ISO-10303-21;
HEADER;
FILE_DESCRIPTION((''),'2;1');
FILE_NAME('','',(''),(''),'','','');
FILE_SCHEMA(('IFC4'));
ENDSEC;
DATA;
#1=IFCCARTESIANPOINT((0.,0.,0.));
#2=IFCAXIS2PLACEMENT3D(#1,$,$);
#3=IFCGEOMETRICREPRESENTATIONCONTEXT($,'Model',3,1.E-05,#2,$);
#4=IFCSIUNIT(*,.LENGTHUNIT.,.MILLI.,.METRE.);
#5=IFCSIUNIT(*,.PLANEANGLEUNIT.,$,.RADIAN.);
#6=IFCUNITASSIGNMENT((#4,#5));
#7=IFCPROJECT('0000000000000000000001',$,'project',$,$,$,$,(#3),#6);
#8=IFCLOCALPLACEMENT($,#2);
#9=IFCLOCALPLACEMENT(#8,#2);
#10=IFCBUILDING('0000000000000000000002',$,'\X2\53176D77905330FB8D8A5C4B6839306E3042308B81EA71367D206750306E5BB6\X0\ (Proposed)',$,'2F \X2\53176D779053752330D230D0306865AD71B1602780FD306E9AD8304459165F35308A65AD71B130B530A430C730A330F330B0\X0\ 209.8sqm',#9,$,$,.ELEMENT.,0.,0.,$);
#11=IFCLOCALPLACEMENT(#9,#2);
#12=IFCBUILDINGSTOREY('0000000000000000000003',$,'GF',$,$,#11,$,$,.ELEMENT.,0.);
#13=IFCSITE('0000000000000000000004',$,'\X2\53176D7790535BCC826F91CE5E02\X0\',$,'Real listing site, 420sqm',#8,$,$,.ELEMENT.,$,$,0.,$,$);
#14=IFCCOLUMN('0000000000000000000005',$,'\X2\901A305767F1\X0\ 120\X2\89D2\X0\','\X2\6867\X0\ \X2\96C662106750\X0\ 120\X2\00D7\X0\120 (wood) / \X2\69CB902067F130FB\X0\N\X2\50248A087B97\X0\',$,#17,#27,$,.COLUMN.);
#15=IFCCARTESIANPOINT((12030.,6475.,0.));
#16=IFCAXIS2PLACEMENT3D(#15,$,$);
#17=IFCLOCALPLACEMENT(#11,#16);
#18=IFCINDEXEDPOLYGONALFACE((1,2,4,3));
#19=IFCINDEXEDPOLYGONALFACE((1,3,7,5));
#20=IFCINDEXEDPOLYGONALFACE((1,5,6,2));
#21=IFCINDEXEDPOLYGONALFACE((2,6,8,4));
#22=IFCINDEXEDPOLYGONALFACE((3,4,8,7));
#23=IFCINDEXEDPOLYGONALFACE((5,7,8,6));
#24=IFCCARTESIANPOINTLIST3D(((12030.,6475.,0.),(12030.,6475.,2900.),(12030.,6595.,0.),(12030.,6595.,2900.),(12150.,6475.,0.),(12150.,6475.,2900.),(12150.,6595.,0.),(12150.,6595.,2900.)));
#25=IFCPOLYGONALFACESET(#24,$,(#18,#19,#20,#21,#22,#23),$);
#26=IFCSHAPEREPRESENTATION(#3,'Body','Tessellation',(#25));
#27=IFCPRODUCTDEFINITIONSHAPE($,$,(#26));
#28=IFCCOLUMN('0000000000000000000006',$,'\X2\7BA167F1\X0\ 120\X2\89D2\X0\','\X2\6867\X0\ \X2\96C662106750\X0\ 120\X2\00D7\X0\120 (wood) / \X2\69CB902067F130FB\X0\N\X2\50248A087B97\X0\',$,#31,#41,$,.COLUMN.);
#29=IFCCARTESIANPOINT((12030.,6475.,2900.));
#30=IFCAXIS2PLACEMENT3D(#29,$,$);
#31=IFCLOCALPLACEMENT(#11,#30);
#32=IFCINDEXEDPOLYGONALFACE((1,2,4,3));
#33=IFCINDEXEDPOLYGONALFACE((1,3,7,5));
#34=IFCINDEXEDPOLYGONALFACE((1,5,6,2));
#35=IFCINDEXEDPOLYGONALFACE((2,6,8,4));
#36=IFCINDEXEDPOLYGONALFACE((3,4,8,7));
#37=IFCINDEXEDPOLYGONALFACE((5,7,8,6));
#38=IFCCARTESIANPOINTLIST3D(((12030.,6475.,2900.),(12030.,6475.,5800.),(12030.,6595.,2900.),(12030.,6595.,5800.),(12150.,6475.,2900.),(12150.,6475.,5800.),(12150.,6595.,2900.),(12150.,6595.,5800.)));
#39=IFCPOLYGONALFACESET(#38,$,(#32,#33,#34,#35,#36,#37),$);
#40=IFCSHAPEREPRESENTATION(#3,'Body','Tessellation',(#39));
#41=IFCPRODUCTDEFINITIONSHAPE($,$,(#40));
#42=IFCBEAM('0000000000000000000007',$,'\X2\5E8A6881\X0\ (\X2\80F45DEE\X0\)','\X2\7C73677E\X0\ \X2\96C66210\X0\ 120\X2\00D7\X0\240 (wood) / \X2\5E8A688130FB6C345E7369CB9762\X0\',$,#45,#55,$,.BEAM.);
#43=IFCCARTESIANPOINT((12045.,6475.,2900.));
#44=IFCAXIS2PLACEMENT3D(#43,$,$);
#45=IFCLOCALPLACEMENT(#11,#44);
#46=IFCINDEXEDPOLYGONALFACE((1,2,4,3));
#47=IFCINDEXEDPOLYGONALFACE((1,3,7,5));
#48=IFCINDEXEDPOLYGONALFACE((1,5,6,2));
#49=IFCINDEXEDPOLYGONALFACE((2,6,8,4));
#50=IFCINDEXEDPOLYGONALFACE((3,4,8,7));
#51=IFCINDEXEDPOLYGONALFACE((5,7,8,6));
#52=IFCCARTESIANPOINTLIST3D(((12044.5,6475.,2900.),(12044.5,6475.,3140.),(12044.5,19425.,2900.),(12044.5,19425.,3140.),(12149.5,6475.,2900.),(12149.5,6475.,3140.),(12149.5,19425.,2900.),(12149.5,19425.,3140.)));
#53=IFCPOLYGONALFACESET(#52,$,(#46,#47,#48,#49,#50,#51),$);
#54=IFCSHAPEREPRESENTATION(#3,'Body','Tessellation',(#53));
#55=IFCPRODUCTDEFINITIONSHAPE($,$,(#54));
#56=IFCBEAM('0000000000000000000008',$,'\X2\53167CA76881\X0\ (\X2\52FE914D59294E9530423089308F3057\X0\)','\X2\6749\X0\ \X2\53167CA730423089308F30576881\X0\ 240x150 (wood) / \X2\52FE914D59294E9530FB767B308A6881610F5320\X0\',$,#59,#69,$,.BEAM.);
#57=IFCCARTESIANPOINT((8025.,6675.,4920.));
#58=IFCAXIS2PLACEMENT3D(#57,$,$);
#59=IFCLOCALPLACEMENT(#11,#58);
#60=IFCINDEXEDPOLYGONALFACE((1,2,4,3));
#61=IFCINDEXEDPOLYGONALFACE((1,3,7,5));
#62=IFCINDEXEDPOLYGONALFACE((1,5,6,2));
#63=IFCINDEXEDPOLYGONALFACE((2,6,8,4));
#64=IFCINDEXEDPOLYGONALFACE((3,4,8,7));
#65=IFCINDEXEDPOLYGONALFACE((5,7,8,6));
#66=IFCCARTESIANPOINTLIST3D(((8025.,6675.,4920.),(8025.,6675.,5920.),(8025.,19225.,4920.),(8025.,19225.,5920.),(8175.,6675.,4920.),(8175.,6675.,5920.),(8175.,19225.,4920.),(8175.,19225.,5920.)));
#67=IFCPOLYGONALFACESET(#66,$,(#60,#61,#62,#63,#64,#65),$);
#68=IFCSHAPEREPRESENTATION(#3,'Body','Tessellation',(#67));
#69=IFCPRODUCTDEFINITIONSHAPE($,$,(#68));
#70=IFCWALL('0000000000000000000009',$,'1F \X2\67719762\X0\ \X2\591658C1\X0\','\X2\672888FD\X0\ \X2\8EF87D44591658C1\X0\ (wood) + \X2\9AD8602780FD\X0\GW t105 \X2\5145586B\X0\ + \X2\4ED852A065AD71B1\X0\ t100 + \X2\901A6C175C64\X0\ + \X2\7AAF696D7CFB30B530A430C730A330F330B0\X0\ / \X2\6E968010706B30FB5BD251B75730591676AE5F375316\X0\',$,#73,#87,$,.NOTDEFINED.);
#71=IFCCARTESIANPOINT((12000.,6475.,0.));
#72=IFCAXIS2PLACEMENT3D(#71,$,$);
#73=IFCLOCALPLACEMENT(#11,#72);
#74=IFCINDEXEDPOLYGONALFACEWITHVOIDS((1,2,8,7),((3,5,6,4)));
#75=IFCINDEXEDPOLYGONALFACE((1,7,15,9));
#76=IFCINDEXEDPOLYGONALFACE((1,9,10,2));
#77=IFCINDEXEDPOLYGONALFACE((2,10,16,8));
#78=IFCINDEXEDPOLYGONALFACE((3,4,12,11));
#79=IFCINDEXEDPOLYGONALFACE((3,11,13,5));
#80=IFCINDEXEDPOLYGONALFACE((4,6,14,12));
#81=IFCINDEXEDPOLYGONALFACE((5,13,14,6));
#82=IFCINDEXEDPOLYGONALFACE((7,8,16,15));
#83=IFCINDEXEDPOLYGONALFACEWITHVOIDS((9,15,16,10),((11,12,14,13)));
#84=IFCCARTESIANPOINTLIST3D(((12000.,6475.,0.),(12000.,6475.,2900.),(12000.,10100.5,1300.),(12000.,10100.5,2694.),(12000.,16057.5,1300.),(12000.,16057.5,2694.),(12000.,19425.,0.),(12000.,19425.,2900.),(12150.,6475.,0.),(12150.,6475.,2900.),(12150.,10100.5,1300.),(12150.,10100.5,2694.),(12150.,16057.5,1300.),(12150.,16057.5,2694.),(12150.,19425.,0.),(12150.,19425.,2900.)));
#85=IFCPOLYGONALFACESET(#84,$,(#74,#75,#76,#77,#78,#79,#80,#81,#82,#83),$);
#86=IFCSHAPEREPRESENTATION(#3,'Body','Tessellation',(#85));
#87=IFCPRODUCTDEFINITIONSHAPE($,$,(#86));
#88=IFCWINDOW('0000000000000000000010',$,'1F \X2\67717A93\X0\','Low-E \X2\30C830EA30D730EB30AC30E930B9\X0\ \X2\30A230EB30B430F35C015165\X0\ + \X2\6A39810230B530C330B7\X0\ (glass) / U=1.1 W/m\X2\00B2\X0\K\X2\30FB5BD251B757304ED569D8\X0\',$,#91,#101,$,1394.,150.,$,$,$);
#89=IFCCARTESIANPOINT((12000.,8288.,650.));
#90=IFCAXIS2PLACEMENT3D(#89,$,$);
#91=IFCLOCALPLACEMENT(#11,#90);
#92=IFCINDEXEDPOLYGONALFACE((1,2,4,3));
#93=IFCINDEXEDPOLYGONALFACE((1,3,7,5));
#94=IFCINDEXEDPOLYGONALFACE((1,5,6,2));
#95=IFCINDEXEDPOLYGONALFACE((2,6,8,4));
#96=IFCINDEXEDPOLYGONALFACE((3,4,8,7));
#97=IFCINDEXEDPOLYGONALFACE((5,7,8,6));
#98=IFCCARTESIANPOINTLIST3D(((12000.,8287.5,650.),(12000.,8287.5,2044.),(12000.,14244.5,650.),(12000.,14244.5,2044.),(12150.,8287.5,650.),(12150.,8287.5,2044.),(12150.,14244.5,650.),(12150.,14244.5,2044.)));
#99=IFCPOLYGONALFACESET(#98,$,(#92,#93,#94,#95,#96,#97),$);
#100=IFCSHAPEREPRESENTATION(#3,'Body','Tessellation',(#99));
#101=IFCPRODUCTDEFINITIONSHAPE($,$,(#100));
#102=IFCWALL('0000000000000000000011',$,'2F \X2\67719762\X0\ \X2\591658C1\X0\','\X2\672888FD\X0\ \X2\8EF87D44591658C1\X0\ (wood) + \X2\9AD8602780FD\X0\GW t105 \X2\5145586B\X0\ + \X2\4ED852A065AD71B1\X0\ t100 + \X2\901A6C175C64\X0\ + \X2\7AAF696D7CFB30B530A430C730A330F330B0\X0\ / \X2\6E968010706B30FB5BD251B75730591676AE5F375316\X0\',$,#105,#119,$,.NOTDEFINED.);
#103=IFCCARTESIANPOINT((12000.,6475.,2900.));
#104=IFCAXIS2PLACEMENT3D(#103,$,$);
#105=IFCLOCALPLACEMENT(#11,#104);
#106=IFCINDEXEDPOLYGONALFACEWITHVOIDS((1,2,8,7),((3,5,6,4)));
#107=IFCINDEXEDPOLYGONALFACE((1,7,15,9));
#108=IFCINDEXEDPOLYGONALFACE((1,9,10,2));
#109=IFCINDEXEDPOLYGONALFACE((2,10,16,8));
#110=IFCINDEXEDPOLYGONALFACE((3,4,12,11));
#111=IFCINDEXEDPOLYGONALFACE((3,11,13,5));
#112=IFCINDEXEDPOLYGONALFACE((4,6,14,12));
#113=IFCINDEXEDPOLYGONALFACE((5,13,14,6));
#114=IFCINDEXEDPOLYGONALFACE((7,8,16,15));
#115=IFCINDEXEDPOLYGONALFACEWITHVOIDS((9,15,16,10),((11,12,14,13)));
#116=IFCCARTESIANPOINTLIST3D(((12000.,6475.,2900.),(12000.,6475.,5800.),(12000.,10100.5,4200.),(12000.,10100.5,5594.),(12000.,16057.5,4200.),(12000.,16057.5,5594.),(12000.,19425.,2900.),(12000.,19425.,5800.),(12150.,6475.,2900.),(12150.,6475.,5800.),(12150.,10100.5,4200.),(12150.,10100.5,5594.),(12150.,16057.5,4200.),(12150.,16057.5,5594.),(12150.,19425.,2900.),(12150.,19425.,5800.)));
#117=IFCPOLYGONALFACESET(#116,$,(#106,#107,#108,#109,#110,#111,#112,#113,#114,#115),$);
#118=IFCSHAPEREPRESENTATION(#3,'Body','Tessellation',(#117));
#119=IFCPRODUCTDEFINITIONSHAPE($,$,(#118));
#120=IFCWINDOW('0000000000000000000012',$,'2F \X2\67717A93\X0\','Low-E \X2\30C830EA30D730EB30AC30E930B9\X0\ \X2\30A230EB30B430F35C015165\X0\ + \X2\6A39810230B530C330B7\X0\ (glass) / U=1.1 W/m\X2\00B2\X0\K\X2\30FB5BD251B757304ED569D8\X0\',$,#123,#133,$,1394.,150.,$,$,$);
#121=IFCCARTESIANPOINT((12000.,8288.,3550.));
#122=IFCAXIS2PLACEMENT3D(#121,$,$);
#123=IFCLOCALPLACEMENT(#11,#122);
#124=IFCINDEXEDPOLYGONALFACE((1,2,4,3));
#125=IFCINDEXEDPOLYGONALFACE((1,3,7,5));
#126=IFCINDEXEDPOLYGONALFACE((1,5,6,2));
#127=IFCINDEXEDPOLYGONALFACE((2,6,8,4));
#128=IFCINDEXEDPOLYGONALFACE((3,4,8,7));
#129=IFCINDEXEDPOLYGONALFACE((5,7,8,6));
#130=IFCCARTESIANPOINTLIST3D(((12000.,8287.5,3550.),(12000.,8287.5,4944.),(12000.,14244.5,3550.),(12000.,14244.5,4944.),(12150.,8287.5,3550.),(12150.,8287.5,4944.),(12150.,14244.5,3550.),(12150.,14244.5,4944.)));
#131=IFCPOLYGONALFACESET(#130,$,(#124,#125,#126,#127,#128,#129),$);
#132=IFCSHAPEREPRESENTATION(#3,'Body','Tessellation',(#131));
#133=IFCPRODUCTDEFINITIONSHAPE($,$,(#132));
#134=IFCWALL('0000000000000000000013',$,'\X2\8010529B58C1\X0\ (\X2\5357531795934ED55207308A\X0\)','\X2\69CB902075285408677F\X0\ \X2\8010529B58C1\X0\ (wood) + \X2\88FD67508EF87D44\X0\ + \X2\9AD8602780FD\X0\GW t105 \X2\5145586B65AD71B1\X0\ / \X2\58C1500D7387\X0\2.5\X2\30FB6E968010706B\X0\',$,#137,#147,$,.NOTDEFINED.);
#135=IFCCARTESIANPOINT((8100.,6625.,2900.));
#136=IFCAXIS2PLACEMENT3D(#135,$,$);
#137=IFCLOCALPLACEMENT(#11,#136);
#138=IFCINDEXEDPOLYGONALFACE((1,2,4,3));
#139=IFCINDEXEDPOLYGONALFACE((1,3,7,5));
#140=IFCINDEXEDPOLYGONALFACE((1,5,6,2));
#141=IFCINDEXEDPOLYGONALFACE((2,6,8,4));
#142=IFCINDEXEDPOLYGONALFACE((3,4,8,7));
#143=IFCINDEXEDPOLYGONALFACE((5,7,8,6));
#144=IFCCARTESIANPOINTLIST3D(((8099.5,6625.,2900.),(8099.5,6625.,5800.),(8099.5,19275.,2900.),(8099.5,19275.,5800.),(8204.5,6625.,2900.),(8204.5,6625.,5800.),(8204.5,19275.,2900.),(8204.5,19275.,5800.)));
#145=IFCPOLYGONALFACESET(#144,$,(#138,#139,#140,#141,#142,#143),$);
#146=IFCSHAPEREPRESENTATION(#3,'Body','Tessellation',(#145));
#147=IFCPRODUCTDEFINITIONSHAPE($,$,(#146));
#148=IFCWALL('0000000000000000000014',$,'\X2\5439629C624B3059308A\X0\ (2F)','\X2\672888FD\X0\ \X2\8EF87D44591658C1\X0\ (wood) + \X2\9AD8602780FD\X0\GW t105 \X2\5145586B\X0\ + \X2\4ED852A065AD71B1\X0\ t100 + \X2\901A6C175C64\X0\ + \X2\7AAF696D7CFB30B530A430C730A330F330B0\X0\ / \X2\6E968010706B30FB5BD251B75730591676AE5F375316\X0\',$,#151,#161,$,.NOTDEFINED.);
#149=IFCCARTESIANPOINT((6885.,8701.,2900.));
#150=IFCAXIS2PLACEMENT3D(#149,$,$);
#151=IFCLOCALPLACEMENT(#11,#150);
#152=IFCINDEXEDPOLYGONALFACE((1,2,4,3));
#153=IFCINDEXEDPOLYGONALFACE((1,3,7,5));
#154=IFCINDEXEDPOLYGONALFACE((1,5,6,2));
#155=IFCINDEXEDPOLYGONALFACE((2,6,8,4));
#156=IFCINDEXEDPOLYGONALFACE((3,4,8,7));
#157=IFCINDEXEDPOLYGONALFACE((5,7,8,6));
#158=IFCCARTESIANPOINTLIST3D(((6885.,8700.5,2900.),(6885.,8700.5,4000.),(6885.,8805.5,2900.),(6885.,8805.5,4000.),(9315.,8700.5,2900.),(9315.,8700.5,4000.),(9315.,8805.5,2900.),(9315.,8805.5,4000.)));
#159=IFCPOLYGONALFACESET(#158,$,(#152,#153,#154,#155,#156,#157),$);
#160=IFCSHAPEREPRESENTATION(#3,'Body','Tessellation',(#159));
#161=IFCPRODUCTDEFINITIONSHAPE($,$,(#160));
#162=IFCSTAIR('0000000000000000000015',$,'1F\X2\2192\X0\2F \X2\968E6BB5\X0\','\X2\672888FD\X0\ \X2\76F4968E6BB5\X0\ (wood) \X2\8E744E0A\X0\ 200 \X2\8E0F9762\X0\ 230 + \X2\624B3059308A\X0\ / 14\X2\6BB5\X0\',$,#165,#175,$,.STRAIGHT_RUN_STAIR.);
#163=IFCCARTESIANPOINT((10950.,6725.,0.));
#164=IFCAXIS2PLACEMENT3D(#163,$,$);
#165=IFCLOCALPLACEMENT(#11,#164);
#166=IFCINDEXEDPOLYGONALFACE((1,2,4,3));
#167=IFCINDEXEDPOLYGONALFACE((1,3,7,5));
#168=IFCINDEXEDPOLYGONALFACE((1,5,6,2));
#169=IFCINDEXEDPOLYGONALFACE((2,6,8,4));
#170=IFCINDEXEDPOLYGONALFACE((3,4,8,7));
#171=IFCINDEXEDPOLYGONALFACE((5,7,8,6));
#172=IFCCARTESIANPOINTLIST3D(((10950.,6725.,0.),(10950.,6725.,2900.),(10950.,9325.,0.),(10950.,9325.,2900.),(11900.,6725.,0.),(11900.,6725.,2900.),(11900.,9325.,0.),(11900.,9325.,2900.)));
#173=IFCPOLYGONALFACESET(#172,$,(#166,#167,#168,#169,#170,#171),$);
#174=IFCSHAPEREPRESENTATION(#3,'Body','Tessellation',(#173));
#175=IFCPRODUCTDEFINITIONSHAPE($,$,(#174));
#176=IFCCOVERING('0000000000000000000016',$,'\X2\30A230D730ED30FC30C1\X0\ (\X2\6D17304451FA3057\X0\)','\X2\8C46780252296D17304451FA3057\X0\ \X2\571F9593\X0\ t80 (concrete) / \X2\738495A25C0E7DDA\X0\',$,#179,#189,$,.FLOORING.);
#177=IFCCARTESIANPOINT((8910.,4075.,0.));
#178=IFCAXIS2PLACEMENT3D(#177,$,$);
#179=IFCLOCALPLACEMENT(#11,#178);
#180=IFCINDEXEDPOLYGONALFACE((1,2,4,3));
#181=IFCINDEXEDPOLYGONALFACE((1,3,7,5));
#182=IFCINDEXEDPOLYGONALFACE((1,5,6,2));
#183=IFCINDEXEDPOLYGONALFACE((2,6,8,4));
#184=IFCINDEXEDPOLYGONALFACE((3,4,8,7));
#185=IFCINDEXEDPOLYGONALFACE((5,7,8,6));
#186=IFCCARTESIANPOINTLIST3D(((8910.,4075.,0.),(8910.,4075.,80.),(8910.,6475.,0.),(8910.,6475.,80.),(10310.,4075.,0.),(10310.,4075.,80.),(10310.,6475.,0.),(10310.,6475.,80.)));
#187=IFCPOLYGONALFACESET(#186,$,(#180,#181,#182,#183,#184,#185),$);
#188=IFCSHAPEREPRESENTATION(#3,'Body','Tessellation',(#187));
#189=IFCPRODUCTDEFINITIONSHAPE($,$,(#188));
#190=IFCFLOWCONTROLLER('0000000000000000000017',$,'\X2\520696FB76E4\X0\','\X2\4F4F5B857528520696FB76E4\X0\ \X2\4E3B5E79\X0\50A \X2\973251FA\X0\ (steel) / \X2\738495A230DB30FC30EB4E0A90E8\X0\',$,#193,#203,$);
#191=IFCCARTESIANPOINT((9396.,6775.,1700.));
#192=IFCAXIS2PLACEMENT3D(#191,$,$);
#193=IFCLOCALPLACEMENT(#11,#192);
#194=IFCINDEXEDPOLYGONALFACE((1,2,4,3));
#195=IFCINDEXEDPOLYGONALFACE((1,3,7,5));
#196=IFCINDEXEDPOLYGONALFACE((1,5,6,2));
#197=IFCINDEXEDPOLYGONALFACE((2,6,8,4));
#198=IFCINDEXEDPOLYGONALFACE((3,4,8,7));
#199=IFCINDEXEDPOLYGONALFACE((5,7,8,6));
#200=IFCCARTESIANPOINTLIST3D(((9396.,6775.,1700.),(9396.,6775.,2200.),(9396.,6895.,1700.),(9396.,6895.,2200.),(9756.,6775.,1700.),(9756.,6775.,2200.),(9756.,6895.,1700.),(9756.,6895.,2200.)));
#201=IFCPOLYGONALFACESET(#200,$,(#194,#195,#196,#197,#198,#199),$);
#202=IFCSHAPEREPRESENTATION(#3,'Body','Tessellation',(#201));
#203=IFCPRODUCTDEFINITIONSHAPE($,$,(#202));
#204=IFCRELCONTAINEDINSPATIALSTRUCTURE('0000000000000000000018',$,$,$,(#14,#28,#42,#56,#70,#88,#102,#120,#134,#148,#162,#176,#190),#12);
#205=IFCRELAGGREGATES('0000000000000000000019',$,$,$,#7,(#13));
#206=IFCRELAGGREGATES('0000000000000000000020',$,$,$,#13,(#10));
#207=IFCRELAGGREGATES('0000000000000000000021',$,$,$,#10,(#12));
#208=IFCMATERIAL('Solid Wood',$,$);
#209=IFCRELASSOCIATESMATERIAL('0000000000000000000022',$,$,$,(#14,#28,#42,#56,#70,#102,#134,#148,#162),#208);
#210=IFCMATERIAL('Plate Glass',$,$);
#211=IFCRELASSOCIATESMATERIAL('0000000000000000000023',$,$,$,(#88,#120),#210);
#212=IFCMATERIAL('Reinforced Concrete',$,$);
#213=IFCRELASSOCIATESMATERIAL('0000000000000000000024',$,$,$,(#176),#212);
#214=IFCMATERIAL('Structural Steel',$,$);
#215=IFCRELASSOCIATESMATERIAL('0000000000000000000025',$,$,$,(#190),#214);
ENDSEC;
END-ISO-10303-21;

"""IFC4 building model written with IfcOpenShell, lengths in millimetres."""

from ifc_helpers import new_model, si_unit, frame, frame_2d, origin, place, context, project, spatial, rectangle, extrude, material, element, fill, save


model = new_model("IFC4")

# Units and contexts
model_context = context("Model", 3, precision=1e-05, world=origin())
ifc_project = project(units=[si_unit("LENGTHUNIT", "METRE", prefix="MILLI"), si_unit("PLANEANGLEUNIT", "RADIAN")], contexts=[model_context])

# Site, building, storey
site_placement = place(None, origin())
site = spatial("IfcSite", under=ifc_project, at=site_placement, Name="北海道富良野市", ObjectType="Real listing site, 420sqm", CompositionType="ELEMENT", RefElevation=0.0)
building_placement = place(site_placement, origin())
building = spatial("IfcBuilding", under=site, at=building_placement, Name="北海道・越屋根のある自然素材の家 (Proposed)", ObjectType="2F 北海道産ヒバと断熱性能の高い外張り断熱サイディング 209.8sqm", CompositionType="ELEMENT", ElevationOfRefHeight=0.0, ElevationOfTerrain=0.0)
storey_placement = place(building_placement, origin())
storey = spatial("IfcBuildingStorey", under=building, at=storey_placement, Name="GF", CompositionType="ELEMENT", Elevation=0.0)

# Columns
ifc_material_1 = material(Name="Solid Wood")
column_1_placement = place(storey_placement, frame((12030.0, 6475.0, 0.0)))
element("IfcColumn", 1, at=column_1_placement, inside=storey, material=ifc_material_1, Name="通し柱 120角", Description="桧 集成材 120×120 (wood) / 構造柱・N値計算", PredefinedType="COLUMN", context=model_context, shape_type="SweptSolid", body=[
    extrude(rectangle(XDim=120.0, YDim=120.0, at=frame_2d((60.0, 60.0))), frame((12030.0, 6475.0, 0.0)), (0.0, 0.0, 1.0), 2900.0),
])
column_2_placement = place(storey_placement, frame((12030.0, 6475.0, 2900.0)))
element("IfcColumn", 2, at=column_2_placement, inside=storey, material=ifc_material_1, Name="管柱 120角", Description="桧 集成材 120×120 (wood) / 構造柱・N値計算", PredefinedType="COLUMN", context=model_context, shape_type="SweptSolid", body=[
    extrude(rectangle(XDim=120.0, YDim=120.0, at=frame_2d((60.0, 60.0))), frame((12030.0, 6475.0, 2900.0)), (0.0, 0.0, 1.0), 2900.0),
])

# Beams
beam_1_placement = place(storey_placement, frame((12045.0, 6475.0, 2900.0)))
element("IfcBeam", 3, at=beam_1_placement, inside=storey, material=ifc_material_1, Name="床梁 (胴差)", Description="米松 集成 120×240 (wood) / 床梁・水平構面", PredefinedType="BEAM", context=model_context, shape_type="SweptSolid", body=[
    extrude(rectangle(XDim=105.0, YDim=12950.0, at=frame_2d((52.0, 6475.0))), frame((12045.0, 6475.0, 2900.0)), (0.0, 0.0, 1.0), 240.0),
])
beam_2_placement = place(storey_placement, frame((8025.0, 6675.0, 4920.0)))
element("IfcBeam", 4, at=beam_2_placement, inside=storey, material=ifc_material_1, Name="化粧梁 (勾配天井あらわし)", Description="杉 化粧あらわし梁 240x150 (wood) / 勾配天井・登り梁意匠", PredefinedType="BEAM", context=model_context, shape_type="SweptSolid", body=[
    extrude(rectangle(XDim=150.0, YDim=12550.0, at=frame_2d((75.0, 6275.0))), frame((8025.0, 6675.0, 4920.0)), (0.0, 0.0, 1.0), 1000.0),
])

# Wall, opening, window
wall_1_placement = place(storey_placement, frame((12000.0, 6475.0, 0.0)))
wall_1 = element("IfcWall", 5, at=wall_1_placement, inside=storey, material=ifc_material_1, Name="1F 東面 外壁", Description="木製 軸組外壁 (wood) + 高性能GW t105 充填 + 付加断熱 t100 + 通気層 + 窯業系サイディング / 準耐火・寒冷地外皮強化", PredefinedType="NOTDEFINED", context=model_context, shape_type="SweptSolid", body=[
    extrude(rectangle(XDim=150.0, YDim=12950.0, at=frame_2d((75.0, 6475.0))), frame((12000.0, 6475.0, 0.0)), (0.0, 0.0, 1.0), 2900.0),
])
opening_1_placement = place(storey_placement, frame((12000.0, 8288.0, 650.0)))
opening_1 = element("IfcOpeningElement", 6, at=opening_1_placement, cuts=wall_1, PredefinedType="NOTDEFINED", context=model_context, shape_type="SweptSolid", body=[
    extrude(rectangle(XDim=150.0, YDim=5957.0, at=frame_2d((75.0, 2978.0))), frame((12000.0, 8288.0, 650.0)), (0.0, 0.0, 1.0), 1394.0),
])
ifc_material_2 = material(Name="Plate Glass")
window_1_placement = place(storey_placement, frame((12000.0, 8288.0, 650.0)))
window_1 = element("IfcWindow", 7, at=window_1_placement, inside=storey, material=ifc_material_2, Name="1F 東窓", Description="Low-E トリプルガラス アルゴン封入 + 樹脂サッシ (glass) / U=1.1 W/m²K・寒冷地仕様", OverallHeight=1394.0, OverallWidth=150.0, context=model_context, shape_type="SweptSolid", body=[
    extrude(rectangle(XDim=150.0, YDim=5957.0, at=frame_2d((75.0, 2978.0))), frame((12000.0, 8288.0, 650.0)), (0.0, 0.0, 1.0), 1394.0),
])
fill(opening_1, window_1)

# Wall, opening, window
wall_2_placement = place(storey_placement, frame((12000.0, 6475.0, 2900.0)))
wall_2 = element("IfcWall", 8, at=wall_2_placement, inside=storey, material=ifc_material_1, Name="2F 東面 外壁", Description="木製 軸組外壁 (wood) + 高性能GW t105 充填 + 付加断熱 t100 + 通気層 + 窯業系サイディング / 準耐火・寒冷地外皮強化", PredefinedType="NOTDEFINED", context=model_context, shape_type="SweptSolid", body=[
    extrude(rectangle(XDim=150.0, YDim=12950.0, at=frame_2d((75.0, 6475.0))), frame((12000.0, 6475.0, 2900.0)), (0.0, 0.0, 1.0), 2900.0),
])
opening_2_placement = place(storey_placement, frame((12000.0, 8288.0, 3550.0)))
opening_2 = element("IfcOpeningElement", 9, at=opening_2_placement, cuts=wall_2, PredefinedType="NOTDEFINED", context=model_context, shape_type="SweptSolid", body=[
    extrude(rectangle(XDim=150.0, YDim=5957.0, at=frame_2d((75.0, 2978.0))), frame((12000.0, 8288.0, 3550.0)), (0.0, 0.0, 1.0), 1394.0),
])
window_2_placement = place(storey_placement, frame((12000.0, 8288.0, 3550.0)))
window_2 = element("IfcWindow", 10, at=window_2_placement, inside=storey, material=ifc_material_2, Name="2F 東窓", Description="Low-E トリプルガラス アルゴン封入 + 樹脂サッシ (glass) / U=1.1 W/m²K・寒冷地仕様", OverallHeight=1394.0, OverallWidth=150.0, context=model_context, shape_type="SweptSolid", body=[
    extrude(rectangle(XDim=150.0, YDim=5957.0, at=frame_2d((75.0, 2978.0))), frame((12000.0, 8288.0, 3550.0)), (0.0, 0.0, 1.0), 1394.0),
])
fill(opening_2, window_2)

# Walls
wall_3_placement = place(storey_placement, frame((8100.0, 6625.0, 2900.0)))
element("IfcWall", 11, at=wall_3_placement, inside=storey, material=ifc_material_1, Name="耐力壁 (南北間仕切り)", Description="構造用合板 耐力壁 (wood) + 製材軸組 + 高性能GW t105 充填断熱 / 壁倍率2.5・準耐火", PredefinedType="NOTDEFINED", context=model_context, shape_type="SweptSolid", body=[
    extrude(rectangle(XDim=105.0, YDim=12650.0, at=frame_2d((52.0, 6325.0))), frame((8100.0, 6625.0, 2900.0)), (0.0, 0.0, 1.0), 2900.0),
])
wall_4_placement = place(storey_placement, frame((6885.0, 8701.0, 2900.0)))
element("IfcWall", 12, at=wall_4_placement, inside=storey, material=ifc_material_1, Name="吹抜手すり (2F)", Description="木製 軸組外壁 (wood) + 高性能GW t105 充填 + 付加断熱 t100 + 通気層 + 窯業系サイディング / 準耐火・寒冷地外皮強化", PredefinedType="NOTDEFINED", context=model_context, shape_type="SweptSolid", body=[
    extrude(rectangle(XDim=2430.0, YDim=105.0, at=frame_2d((1215.0, 52.0))), frame((6885.0, 8701.0, 2900.0)), (0.0, 0.0, 1.0), 1100.0),
])

# Stair
stair_placement = place(storey_placement, frame((10950.0, 6725.0, 0.0)))
element("IfcStair", 13, at=stair_placement, inside=storey, material=ifc_material_1, Name="1F→2F 階段", Description="木製 直階段 (wood) 蹴上 200 踏面 230 + 手すり / 14段", PredefinedType="STRAIGHT_RUN_STAIR", context=model_context, shape_type="SweptSolid", body=[
    extrude(rectangle(XDim=950.0, YDim=2600.0, at=frame_2d((475.0, 1300.0))), frame((10950.0, 6725.0, 0.0)), (0.0, 0.0, 1.0), 2900.0),
])

# Covering
ifc_material_3 = material(Name="Reinforced Concrete")
covering_placement = place(storey_placement, frame((8910.0, 4075.0, 0.0)))
element("IfcCovering", 14, at=covering_placement, inside=storey, material=ifc_material_3, Name="アプローチ (洗い出し)", Description="豆砂利洗い出し 土間 t80 (concrete) / 玄関導線", PredefinedType="FLOORING", context=model_context, shape_type="SweptSolid", body=[
    extrude(rectangle(XDim=1400.0, YDim=2400.0, at=frame_2d((700.0, 1200.0))), frame((8910.0, 4075.0, 0.0)), (0.0, 0.0, 1.0), 80.0),
])

# Flow controller
ifc_material_4 = material(Name="Structural Steel")
flow_controller_placement = place(storey_placement, frame((9396.0, 6775.0, 1700.0)))
element("IfcFlowController", 15, at=flow_controller_placement, inside=storey, material=ifc_material_4, Name="分電盤", Description="住宅用分電盤 主幹50A 露出 (steel) / 玄関ホール上部", context=model_context, shape_type="SweptSolid", body=[
    extrude(rectangle(XDim=360.0, YDim=120.0, at=frame_2d((180.0, 60.0))), frame((9396.0, 6775.0, 1700.0)), (0.0, 0.0, 1.0), 500.0),
])

save(model, "model.ifc")
